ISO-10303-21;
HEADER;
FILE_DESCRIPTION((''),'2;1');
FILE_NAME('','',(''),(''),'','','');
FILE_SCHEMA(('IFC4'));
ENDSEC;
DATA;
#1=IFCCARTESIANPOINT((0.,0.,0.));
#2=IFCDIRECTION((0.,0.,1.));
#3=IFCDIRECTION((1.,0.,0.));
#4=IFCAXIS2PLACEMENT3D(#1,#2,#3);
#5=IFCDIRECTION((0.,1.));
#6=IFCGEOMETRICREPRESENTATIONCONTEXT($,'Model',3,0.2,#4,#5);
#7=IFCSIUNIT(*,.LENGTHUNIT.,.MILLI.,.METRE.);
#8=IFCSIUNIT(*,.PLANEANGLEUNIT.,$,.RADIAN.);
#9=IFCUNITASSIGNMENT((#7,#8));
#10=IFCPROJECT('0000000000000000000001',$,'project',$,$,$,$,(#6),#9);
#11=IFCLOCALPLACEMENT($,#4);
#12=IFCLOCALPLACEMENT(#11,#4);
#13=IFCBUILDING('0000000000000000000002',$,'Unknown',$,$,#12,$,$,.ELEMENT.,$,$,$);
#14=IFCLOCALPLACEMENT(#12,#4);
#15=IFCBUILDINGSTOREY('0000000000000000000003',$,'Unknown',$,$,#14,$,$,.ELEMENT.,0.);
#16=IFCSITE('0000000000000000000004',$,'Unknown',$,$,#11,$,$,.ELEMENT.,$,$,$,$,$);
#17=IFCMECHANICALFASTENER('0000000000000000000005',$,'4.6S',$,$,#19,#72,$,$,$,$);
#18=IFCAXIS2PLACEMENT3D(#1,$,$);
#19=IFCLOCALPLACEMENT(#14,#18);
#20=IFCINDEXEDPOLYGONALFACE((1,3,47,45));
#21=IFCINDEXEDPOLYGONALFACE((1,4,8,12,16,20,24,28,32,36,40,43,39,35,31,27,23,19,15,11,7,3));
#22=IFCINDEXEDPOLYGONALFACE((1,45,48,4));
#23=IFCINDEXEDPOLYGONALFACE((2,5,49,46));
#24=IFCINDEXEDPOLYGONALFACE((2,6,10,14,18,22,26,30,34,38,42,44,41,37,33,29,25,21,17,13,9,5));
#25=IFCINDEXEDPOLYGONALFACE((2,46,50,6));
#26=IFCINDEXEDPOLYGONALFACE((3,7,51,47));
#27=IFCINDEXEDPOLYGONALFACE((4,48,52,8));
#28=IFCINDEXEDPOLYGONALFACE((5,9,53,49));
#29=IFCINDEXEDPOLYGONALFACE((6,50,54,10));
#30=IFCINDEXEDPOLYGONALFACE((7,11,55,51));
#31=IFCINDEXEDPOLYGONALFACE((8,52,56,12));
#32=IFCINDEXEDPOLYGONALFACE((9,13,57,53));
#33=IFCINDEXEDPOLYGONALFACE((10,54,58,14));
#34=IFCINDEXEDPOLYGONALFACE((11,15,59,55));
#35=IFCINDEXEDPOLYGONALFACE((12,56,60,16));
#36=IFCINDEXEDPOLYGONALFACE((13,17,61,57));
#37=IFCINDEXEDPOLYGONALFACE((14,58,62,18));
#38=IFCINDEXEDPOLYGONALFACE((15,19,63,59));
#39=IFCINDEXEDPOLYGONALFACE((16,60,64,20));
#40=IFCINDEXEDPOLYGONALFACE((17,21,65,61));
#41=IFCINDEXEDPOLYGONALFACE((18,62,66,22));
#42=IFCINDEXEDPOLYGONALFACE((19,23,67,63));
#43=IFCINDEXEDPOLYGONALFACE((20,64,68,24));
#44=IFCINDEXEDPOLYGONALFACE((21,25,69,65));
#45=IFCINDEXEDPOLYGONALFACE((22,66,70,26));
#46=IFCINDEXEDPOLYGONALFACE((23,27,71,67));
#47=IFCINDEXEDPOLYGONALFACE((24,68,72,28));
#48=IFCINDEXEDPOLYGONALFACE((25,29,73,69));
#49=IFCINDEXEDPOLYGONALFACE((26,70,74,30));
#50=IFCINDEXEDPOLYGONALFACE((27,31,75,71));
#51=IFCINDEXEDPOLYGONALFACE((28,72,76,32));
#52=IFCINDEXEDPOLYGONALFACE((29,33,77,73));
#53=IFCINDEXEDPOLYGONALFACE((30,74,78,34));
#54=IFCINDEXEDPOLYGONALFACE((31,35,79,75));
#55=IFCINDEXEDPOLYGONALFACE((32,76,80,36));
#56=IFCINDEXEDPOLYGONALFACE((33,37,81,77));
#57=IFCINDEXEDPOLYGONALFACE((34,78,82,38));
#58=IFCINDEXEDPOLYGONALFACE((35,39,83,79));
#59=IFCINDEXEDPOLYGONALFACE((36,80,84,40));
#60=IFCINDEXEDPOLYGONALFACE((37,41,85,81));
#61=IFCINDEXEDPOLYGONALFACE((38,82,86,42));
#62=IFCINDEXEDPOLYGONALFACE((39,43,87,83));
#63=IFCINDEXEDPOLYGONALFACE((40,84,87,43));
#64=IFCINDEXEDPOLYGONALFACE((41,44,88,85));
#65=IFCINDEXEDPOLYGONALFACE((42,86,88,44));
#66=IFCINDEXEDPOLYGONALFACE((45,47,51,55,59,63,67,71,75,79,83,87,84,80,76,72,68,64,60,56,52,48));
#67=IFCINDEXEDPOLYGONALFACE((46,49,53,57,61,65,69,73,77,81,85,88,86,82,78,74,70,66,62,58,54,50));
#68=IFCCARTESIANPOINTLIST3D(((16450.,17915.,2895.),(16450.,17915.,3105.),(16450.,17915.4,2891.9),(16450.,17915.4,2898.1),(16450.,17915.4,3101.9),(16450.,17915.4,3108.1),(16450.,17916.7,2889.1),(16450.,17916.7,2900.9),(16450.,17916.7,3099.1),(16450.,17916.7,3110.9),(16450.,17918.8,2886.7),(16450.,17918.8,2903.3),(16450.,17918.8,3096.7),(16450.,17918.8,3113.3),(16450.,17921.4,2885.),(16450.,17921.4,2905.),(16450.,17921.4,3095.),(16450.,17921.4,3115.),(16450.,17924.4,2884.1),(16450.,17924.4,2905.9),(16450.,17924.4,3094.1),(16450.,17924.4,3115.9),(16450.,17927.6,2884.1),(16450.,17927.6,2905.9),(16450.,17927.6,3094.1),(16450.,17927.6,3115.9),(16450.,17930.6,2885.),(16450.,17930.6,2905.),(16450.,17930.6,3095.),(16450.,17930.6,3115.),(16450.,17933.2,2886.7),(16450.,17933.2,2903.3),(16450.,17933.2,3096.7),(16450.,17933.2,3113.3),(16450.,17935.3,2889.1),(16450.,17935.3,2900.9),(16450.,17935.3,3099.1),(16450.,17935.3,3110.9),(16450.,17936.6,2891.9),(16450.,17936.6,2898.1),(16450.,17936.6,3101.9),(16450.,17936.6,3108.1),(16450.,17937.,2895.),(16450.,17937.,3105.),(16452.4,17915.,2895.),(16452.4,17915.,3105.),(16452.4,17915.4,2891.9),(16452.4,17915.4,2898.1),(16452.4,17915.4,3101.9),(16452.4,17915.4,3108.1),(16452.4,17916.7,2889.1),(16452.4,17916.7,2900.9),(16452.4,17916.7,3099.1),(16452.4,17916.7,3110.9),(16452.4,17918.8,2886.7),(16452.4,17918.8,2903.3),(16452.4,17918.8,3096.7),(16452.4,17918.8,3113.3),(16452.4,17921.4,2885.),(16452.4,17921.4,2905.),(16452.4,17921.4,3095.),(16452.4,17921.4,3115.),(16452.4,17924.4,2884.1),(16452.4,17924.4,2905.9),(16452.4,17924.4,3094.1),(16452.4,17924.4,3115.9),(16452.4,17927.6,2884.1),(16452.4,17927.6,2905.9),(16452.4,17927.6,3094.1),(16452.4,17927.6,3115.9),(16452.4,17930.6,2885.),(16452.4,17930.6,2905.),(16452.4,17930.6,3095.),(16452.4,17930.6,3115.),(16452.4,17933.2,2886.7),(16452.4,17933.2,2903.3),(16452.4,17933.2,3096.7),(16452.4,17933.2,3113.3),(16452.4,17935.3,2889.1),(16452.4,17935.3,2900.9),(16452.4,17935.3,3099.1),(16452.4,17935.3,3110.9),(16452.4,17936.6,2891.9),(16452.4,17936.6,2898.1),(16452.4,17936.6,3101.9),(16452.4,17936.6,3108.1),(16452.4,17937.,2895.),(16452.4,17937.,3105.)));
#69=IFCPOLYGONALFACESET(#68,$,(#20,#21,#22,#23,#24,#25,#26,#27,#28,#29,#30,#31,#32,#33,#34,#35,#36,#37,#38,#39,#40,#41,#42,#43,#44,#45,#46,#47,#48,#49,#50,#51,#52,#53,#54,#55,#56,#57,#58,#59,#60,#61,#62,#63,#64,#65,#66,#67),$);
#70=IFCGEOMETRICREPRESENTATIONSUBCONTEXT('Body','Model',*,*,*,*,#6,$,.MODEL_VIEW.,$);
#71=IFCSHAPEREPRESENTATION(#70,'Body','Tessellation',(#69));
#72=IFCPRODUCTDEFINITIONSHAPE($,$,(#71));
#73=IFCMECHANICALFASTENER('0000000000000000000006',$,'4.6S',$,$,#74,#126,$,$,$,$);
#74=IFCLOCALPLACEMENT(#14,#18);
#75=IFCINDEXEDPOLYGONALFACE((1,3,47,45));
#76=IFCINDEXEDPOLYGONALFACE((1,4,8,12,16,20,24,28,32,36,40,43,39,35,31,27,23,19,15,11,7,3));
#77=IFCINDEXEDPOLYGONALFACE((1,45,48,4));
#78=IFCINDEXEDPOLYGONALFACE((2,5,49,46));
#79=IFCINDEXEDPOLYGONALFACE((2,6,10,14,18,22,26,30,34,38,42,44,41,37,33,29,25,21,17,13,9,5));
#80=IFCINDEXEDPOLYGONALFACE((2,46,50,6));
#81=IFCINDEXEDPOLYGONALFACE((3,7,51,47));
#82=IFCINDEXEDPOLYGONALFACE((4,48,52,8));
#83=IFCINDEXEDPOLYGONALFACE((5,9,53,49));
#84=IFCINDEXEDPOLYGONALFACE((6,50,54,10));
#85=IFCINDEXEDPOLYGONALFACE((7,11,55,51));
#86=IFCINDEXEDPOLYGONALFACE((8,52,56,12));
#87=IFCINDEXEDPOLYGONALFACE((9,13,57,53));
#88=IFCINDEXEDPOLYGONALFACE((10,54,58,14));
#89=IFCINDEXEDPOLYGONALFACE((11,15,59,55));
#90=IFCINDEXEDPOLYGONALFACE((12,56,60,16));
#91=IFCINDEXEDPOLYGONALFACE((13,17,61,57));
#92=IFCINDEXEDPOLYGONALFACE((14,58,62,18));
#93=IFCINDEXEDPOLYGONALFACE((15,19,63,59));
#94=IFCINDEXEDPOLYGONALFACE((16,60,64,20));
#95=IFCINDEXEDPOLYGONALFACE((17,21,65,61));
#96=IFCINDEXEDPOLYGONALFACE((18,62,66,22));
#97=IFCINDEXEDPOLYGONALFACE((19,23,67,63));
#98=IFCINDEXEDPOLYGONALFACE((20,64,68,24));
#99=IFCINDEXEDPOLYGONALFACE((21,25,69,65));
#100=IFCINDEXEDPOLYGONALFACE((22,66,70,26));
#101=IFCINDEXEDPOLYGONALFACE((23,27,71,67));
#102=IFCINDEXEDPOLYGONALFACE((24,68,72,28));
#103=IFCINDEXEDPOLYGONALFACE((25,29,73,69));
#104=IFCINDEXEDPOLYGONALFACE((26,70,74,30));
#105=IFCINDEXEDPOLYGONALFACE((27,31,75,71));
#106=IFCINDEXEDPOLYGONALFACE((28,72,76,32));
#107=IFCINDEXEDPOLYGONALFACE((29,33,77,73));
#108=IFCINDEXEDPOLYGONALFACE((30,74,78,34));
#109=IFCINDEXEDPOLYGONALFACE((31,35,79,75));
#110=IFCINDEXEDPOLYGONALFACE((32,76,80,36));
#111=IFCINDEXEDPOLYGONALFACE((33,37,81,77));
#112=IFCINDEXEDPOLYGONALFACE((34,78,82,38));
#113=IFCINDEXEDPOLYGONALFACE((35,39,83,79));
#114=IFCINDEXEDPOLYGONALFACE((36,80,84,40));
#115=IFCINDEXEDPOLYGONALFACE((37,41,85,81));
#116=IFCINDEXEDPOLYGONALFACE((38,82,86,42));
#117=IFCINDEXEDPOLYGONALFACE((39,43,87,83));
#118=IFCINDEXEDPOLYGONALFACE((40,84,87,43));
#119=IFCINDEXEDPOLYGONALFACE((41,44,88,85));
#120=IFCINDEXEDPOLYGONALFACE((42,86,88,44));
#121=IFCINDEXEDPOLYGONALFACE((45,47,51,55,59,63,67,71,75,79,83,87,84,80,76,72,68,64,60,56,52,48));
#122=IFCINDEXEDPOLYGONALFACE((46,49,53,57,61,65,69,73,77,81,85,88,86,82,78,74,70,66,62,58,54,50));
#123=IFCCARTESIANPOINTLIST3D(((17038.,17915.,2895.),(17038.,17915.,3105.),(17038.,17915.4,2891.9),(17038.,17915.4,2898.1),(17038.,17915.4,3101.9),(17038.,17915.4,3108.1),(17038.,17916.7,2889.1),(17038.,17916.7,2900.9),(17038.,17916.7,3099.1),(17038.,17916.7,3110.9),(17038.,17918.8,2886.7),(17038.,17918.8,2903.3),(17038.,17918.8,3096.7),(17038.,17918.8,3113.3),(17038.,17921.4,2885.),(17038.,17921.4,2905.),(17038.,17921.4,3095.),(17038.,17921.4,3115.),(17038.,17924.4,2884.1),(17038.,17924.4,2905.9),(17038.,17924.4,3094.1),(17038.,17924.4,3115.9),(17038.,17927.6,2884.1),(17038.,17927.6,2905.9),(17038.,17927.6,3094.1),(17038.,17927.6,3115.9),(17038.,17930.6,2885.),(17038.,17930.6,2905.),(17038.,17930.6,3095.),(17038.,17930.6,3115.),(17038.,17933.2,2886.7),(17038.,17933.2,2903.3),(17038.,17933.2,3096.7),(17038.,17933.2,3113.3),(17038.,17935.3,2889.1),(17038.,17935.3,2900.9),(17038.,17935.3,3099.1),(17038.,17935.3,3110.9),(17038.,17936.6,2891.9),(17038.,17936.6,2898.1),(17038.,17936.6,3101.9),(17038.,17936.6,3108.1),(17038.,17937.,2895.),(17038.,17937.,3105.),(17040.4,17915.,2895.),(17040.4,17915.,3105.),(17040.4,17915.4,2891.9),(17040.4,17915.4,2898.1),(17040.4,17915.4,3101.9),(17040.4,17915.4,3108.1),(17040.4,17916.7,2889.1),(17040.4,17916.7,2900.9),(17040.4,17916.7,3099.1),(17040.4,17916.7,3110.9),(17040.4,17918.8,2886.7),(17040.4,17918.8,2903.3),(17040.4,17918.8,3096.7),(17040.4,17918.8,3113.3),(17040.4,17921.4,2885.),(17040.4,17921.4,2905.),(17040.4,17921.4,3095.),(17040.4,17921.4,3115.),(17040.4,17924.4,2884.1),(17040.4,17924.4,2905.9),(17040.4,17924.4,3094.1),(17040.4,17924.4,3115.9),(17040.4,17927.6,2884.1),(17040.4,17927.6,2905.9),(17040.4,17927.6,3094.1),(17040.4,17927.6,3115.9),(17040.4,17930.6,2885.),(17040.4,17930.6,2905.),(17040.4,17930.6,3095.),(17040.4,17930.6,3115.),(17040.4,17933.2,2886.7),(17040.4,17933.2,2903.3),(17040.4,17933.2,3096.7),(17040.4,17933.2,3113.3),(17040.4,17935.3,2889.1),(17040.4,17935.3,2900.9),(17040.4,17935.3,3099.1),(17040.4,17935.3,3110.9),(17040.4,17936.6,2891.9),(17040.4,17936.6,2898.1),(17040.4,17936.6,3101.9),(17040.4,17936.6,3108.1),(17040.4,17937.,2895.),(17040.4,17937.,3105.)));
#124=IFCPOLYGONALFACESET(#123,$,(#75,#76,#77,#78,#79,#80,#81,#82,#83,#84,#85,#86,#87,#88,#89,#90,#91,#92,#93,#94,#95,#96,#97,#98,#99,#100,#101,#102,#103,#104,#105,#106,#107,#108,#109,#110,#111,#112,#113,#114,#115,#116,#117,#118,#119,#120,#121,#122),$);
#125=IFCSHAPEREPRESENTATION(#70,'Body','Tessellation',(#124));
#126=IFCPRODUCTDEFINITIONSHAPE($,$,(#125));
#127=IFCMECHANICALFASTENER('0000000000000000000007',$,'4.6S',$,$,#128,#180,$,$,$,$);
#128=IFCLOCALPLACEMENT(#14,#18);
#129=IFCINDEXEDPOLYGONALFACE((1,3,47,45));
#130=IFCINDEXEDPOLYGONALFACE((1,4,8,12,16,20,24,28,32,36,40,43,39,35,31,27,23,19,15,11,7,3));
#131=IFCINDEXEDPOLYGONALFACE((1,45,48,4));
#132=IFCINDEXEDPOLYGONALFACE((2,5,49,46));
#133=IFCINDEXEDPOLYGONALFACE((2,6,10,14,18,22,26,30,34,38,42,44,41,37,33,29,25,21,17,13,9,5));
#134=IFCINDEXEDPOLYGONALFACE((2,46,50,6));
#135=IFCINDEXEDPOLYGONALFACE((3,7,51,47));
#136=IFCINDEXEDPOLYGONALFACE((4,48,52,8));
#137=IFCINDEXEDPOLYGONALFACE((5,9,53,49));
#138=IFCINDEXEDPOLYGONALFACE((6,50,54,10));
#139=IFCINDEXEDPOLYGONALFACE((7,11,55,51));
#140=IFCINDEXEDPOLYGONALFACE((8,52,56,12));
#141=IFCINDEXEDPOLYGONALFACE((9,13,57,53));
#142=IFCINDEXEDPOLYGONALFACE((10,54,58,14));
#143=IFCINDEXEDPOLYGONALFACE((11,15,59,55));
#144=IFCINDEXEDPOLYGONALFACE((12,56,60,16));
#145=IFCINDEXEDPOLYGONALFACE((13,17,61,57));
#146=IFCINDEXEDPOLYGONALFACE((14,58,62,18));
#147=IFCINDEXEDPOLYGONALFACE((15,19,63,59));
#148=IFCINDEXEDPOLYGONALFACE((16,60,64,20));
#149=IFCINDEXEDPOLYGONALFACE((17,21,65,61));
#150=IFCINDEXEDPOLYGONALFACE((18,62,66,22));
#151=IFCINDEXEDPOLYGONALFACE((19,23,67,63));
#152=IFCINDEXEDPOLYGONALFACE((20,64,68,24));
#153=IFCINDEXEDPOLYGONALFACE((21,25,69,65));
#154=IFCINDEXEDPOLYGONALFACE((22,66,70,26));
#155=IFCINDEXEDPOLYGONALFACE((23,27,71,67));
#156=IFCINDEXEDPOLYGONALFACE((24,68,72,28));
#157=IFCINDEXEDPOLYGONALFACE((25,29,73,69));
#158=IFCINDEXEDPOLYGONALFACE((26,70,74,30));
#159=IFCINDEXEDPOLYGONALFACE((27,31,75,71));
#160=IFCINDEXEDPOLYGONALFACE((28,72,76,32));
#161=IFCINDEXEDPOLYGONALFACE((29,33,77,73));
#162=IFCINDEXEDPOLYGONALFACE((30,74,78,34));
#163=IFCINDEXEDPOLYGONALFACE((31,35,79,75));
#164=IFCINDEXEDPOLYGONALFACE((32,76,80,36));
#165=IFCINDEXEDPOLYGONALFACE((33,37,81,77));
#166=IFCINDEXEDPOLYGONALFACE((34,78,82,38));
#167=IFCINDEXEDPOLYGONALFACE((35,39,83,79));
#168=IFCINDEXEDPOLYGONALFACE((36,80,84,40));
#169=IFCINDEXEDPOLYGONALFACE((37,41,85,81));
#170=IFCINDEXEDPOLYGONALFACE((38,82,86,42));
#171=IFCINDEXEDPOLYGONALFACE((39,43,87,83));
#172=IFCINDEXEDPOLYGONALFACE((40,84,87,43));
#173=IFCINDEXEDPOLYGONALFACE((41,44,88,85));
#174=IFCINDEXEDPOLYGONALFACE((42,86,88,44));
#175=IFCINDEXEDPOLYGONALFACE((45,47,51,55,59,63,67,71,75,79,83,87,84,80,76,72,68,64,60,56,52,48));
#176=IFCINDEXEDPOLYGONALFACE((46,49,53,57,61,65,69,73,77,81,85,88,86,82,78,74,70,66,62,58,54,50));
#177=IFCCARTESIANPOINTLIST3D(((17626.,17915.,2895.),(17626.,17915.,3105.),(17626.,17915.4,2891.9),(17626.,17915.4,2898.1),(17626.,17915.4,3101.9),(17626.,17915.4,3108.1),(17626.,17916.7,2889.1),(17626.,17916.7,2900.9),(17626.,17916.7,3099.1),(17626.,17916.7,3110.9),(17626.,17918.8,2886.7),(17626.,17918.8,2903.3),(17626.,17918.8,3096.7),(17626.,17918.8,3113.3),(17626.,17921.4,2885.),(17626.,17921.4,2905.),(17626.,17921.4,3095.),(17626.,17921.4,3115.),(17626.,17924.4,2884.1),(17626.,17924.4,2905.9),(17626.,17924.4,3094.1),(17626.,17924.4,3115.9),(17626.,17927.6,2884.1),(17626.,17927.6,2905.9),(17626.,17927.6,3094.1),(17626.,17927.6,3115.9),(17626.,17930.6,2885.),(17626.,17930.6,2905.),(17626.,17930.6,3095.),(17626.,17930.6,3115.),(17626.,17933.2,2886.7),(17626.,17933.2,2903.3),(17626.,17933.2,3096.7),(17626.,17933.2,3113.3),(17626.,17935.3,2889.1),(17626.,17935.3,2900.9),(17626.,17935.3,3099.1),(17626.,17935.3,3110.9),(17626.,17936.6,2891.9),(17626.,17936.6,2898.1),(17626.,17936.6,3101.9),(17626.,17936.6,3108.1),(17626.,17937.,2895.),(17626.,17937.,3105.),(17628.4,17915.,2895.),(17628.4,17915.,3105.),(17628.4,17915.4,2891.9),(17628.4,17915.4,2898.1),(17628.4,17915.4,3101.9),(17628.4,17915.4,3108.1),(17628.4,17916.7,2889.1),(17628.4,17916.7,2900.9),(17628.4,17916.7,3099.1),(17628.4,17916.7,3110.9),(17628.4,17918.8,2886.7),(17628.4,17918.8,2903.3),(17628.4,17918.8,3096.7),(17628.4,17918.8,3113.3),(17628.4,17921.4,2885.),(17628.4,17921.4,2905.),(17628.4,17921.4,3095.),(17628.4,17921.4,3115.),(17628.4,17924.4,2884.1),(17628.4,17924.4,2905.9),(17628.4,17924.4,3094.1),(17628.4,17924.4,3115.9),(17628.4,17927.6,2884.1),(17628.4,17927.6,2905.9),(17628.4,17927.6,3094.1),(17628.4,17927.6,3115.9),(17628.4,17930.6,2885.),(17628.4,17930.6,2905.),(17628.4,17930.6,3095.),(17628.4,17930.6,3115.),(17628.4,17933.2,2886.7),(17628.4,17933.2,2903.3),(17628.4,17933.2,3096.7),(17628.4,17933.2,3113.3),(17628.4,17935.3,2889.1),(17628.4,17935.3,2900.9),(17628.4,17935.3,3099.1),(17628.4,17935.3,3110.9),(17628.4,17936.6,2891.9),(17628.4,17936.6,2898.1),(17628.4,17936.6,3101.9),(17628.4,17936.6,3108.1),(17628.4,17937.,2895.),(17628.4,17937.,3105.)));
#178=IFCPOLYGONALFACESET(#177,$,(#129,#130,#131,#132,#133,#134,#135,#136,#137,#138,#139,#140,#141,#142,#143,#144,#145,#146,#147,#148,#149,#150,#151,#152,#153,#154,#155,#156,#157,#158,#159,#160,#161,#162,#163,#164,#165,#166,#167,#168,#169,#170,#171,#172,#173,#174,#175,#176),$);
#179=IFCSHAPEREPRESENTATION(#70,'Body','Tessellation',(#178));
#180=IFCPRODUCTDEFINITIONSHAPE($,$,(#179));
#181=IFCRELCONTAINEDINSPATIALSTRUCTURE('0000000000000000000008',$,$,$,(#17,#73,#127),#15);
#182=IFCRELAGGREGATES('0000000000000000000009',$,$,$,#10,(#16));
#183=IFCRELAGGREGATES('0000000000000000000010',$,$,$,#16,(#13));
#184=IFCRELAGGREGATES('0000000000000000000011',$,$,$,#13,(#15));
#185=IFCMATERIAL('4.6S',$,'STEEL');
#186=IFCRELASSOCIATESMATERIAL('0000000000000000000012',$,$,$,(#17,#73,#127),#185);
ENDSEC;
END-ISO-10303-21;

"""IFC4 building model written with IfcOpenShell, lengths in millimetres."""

from ifc_helpers import new_model, si_unit, direction, frame, origin_with_axes, place, context, subcontext, project, spatial, arc, indexed_curve, outline, extrude, source, transform, mapped, material, element, save


model = new_model("IFC4")

# Units and contexts
model_context = context("Model", 3, precision=0.2, world=origin_with_axes(), true_north=direction((0.0, 1.0)))
body_context = subcontext(model_context, "Body", "Model", "MODEL_VIEW")
ifc_project = project(units=[si_unit("LENGTHUNIT", "METRE", prefix="MILLI"), si_unit("PLANEANGLEUNIT", "RADIAN")], contexts=[model_context])

# Site, building, storey
site_placement = place(None, origin_with_axes())
site = spatial("IfcSite", under=ifc_project, at=site_placement, Name="Unknown", CompositionType="ELEMENT")
building_placement = place(site_placement, origin_with_axes())
building = spatial("IfcBuilding", under=site, at=building_placement, Name="Unknown", CompositionType="ELEMENT")
storey_placement = place(building_placement, origin_with_axes())
storey = spatial("IfcBuildingStorey", under=building, at=storey_placement, Name="Unknown", CompositionType="ELEMENT", Elevation=0.0)

# Mechanical fasteners
ifc_material_1 = material(Name="4.6S", Category="STEEL")
shared_shape_1 = source(origin_with_axes(), body_context, "Body", "SweptSolid", [
    extrude(outline(indexed_curve([(11.0, 0.0), (0.0, 11.0), (-11.0, 0.0), (0.0, -11.0)], segments=[arc(1, 2, 3), arc(3, 4, 1)])), frame((0.0, 0.0, 1.2), z_axis=(0.0, 0.0, -1.0), x_axis=(0.0, 1.0, 0.0)), (0.0, 0.0, 1.0), 2.4),
])
for number, where, z_axis, x_axis, name in (
    (1, (16451.2, 17926.0, 2895.0), (-1.0, 0.0, 0.0), (0.0, 0.0, 1.0), "4.6S"),
    (2, (17039.2, 17926.0, 2895.0), (-1.0, 0.0, 0.0), (0.0, 0.0, 1.0), "4.6S"),
    (3, (17627.2, 17926.0, 2895.0), (-1.0, 0.0, 0.0), (0.0, 0.0, 1.0), "4.6S"),
):
    element("IfcMechanicalFastener", number, at=place(storey_placement, frame(where, z_axis=z_axis, x_axis=x_axis)), inside=storey, material=ifc_material_1, Name=name, context=body_context, shape_type="MappedRepresentation", body=[
        mapped(shared_shape_1, transform((0.0, 0.0, 0.0))),
        mapped(shared_shape_1, transform((210.0, 0.0, 0.0))),
    ])

save(model, "model.ifc")
